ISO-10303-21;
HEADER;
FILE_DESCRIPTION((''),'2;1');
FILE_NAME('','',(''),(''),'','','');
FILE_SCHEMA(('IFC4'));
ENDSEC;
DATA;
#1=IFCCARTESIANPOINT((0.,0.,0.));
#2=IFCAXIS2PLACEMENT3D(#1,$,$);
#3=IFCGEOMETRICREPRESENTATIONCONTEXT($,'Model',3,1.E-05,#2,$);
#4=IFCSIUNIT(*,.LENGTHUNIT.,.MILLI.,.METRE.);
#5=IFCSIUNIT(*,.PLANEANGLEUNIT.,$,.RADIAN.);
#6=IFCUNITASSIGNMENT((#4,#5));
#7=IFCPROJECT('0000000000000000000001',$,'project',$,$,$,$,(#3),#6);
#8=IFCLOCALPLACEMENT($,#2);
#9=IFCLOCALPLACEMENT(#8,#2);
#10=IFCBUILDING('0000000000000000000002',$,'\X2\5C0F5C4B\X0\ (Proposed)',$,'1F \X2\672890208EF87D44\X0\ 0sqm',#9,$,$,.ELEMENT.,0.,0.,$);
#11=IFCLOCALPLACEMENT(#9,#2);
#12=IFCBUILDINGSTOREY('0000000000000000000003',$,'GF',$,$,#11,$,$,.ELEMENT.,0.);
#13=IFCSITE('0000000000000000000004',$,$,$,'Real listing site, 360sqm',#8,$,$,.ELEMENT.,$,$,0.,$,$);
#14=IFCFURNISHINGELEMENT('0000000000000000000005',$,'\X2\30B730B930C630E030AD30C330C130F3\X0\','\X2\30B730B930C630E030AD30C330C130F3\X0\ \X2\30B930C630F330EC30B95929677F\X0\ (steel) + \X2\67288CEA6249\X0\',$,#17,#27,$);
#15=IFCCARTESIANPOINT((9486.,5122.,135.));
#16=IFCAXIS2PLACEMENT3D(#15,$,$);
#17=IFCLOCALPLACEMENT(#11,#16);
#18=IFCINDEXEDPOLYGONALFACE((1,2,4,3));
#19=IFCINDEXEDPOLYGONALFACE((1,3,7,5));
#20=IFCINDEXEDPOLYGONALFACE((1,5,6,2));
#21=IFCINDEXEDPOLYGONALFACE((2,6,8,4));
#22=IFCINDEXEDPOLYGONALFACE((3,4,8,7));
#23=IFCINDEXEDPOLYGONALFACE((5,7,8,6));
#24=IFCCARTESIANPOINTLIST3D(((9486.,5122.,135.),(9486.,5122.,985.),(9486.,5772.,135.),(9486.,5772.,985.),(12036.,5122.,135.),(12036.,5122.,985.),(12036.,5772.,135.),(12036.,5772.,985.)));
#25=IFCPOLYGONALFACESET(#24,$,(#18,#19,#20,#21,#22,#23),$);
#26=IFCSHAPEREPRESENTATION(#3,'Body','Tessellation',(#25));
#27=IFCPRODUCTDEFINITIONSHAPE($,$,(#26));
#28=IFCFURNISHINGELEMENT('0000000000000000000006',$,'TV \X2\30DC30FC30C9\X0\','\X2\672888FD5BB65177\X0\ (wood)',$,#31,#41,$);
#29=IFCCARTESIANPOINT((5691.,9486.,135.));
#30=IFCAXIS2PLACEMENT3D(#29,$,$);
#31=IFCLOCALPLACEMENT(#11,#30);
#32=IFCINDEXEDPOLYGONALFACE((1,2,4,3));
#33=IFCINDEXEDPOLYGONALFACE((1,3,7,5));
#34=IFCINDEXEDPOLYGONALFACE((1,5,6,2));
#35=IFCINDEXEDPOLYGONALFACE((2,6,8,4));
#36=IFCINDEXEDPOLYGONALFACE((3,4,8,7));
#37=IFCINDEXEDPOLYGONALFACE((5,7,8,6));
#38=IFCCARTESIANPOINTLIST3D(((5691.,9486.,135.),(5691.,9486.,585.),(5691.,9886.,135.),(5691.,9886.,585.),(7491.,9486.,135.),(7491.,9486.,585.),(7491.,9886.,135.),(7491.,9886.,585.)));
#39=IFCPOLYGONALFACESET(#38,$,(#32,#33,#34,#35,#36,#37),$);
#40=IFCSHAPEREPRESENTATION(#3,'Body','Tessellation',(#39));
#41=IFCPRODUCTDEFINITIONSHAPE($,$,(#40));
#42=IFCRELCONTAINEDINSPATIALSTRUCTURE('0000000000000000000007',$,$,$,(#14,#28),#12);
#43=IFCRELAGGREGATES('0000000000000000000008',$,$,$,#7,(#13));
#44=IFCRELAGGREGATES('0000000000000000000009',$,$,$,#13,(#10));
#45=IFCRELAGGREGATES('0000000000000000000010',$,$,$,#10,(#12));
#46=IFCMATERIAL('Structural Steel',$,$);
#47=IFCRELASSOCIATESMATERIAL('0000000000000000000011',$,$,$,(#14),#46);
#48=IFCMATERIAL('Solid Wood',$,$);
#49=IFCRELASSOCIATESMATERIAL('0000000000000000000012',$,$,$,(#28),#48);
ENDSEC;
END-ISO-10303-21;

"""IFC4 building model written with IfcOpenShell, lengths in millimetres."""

from ifc_helpers import new_model, si_unit, frame, frame_2d, origin, place, context, project, spatial, rectangle, extrude, material, element, save


model = new_model("IFC4")

# Units and contexts
model_context = context("Model", 3, precision=1e-05, world=origin())
ifc_project = project(units=[si_unit("LENGTHUNIT", "METRE", prefix="MILLI"), si_unit("PLANEANGLEUNIT", "RADIAN")], contexts=[model_context])

# Site, building, storey
site_placement = place(None, origin())
site = spatial("IfcSite", under=ifc_project, at=site_placement, ObjectType="Real listing site, 360sqm", CompositionType="ELEMENT", RefElevation=0.0)
building_placement = place(site_placement, origin())
building = spatial("IfcBuilding", under=site, at=building_placement, Name="小屋 (Proposed)", ObjectType="1F 木造軸組 0sqm", CompositionType="ELEMENT", ElevationOfRefHeight=0.0, ElevationOfTerrain=0.0)
storey_placement = place(building_placement, origin())
storey = spatial("IfcBuildingStorey", under=building, at=storey_placement, Name="GF", CompositionType="ELEMENT", Elevation=0.0)

# Shared definitions
ifc_material_1 = material(Name="Solid Wood")

# Furnishing elements
ifc_material_2 = material(Name="Structural Steel")
furnishing_1_placement = place(storey_placement, frame((9486.0, 5122.0, 135.0)))
element("IfcFurnishingElement", 1, at=furnishing_1_placement, inside=storey, material=ifc_material_2, Name="システムキッチン", Description="システムキッチン ステンレス天板 (steel) + 木質扉", context=model_context, shape_type="SweptSolid", body=[
    extrude(rectangle(XDim=2550.0, YDim=650.0, at=frame_2d((1275.0, 325.0))), frame((9486.0, 5122.0, 135.0)), (0.0, 0.0, 1.0), 850.0),
])
furnishing_2_placement = place(storey_placement, frame((5691.0, 9486.0, 135.0)))
element("IfcFurnishingElement", 2, at=furnishing_2_placement, inside=storey, material=ifc_material_1, Name="TV ボード", Description="木製家具 (wood)", context=model_context, shape_type="SweptSolid", body=[
    extrude(rectangle(XDim=1800.0, YDim=400.0, at=frame_2d((900.0, 200.0))), frame((5691.0, 9486.0, 135.0)), (0.0, 0.0, 1.0), 450.0),
])

save(model, "model.ifc")
